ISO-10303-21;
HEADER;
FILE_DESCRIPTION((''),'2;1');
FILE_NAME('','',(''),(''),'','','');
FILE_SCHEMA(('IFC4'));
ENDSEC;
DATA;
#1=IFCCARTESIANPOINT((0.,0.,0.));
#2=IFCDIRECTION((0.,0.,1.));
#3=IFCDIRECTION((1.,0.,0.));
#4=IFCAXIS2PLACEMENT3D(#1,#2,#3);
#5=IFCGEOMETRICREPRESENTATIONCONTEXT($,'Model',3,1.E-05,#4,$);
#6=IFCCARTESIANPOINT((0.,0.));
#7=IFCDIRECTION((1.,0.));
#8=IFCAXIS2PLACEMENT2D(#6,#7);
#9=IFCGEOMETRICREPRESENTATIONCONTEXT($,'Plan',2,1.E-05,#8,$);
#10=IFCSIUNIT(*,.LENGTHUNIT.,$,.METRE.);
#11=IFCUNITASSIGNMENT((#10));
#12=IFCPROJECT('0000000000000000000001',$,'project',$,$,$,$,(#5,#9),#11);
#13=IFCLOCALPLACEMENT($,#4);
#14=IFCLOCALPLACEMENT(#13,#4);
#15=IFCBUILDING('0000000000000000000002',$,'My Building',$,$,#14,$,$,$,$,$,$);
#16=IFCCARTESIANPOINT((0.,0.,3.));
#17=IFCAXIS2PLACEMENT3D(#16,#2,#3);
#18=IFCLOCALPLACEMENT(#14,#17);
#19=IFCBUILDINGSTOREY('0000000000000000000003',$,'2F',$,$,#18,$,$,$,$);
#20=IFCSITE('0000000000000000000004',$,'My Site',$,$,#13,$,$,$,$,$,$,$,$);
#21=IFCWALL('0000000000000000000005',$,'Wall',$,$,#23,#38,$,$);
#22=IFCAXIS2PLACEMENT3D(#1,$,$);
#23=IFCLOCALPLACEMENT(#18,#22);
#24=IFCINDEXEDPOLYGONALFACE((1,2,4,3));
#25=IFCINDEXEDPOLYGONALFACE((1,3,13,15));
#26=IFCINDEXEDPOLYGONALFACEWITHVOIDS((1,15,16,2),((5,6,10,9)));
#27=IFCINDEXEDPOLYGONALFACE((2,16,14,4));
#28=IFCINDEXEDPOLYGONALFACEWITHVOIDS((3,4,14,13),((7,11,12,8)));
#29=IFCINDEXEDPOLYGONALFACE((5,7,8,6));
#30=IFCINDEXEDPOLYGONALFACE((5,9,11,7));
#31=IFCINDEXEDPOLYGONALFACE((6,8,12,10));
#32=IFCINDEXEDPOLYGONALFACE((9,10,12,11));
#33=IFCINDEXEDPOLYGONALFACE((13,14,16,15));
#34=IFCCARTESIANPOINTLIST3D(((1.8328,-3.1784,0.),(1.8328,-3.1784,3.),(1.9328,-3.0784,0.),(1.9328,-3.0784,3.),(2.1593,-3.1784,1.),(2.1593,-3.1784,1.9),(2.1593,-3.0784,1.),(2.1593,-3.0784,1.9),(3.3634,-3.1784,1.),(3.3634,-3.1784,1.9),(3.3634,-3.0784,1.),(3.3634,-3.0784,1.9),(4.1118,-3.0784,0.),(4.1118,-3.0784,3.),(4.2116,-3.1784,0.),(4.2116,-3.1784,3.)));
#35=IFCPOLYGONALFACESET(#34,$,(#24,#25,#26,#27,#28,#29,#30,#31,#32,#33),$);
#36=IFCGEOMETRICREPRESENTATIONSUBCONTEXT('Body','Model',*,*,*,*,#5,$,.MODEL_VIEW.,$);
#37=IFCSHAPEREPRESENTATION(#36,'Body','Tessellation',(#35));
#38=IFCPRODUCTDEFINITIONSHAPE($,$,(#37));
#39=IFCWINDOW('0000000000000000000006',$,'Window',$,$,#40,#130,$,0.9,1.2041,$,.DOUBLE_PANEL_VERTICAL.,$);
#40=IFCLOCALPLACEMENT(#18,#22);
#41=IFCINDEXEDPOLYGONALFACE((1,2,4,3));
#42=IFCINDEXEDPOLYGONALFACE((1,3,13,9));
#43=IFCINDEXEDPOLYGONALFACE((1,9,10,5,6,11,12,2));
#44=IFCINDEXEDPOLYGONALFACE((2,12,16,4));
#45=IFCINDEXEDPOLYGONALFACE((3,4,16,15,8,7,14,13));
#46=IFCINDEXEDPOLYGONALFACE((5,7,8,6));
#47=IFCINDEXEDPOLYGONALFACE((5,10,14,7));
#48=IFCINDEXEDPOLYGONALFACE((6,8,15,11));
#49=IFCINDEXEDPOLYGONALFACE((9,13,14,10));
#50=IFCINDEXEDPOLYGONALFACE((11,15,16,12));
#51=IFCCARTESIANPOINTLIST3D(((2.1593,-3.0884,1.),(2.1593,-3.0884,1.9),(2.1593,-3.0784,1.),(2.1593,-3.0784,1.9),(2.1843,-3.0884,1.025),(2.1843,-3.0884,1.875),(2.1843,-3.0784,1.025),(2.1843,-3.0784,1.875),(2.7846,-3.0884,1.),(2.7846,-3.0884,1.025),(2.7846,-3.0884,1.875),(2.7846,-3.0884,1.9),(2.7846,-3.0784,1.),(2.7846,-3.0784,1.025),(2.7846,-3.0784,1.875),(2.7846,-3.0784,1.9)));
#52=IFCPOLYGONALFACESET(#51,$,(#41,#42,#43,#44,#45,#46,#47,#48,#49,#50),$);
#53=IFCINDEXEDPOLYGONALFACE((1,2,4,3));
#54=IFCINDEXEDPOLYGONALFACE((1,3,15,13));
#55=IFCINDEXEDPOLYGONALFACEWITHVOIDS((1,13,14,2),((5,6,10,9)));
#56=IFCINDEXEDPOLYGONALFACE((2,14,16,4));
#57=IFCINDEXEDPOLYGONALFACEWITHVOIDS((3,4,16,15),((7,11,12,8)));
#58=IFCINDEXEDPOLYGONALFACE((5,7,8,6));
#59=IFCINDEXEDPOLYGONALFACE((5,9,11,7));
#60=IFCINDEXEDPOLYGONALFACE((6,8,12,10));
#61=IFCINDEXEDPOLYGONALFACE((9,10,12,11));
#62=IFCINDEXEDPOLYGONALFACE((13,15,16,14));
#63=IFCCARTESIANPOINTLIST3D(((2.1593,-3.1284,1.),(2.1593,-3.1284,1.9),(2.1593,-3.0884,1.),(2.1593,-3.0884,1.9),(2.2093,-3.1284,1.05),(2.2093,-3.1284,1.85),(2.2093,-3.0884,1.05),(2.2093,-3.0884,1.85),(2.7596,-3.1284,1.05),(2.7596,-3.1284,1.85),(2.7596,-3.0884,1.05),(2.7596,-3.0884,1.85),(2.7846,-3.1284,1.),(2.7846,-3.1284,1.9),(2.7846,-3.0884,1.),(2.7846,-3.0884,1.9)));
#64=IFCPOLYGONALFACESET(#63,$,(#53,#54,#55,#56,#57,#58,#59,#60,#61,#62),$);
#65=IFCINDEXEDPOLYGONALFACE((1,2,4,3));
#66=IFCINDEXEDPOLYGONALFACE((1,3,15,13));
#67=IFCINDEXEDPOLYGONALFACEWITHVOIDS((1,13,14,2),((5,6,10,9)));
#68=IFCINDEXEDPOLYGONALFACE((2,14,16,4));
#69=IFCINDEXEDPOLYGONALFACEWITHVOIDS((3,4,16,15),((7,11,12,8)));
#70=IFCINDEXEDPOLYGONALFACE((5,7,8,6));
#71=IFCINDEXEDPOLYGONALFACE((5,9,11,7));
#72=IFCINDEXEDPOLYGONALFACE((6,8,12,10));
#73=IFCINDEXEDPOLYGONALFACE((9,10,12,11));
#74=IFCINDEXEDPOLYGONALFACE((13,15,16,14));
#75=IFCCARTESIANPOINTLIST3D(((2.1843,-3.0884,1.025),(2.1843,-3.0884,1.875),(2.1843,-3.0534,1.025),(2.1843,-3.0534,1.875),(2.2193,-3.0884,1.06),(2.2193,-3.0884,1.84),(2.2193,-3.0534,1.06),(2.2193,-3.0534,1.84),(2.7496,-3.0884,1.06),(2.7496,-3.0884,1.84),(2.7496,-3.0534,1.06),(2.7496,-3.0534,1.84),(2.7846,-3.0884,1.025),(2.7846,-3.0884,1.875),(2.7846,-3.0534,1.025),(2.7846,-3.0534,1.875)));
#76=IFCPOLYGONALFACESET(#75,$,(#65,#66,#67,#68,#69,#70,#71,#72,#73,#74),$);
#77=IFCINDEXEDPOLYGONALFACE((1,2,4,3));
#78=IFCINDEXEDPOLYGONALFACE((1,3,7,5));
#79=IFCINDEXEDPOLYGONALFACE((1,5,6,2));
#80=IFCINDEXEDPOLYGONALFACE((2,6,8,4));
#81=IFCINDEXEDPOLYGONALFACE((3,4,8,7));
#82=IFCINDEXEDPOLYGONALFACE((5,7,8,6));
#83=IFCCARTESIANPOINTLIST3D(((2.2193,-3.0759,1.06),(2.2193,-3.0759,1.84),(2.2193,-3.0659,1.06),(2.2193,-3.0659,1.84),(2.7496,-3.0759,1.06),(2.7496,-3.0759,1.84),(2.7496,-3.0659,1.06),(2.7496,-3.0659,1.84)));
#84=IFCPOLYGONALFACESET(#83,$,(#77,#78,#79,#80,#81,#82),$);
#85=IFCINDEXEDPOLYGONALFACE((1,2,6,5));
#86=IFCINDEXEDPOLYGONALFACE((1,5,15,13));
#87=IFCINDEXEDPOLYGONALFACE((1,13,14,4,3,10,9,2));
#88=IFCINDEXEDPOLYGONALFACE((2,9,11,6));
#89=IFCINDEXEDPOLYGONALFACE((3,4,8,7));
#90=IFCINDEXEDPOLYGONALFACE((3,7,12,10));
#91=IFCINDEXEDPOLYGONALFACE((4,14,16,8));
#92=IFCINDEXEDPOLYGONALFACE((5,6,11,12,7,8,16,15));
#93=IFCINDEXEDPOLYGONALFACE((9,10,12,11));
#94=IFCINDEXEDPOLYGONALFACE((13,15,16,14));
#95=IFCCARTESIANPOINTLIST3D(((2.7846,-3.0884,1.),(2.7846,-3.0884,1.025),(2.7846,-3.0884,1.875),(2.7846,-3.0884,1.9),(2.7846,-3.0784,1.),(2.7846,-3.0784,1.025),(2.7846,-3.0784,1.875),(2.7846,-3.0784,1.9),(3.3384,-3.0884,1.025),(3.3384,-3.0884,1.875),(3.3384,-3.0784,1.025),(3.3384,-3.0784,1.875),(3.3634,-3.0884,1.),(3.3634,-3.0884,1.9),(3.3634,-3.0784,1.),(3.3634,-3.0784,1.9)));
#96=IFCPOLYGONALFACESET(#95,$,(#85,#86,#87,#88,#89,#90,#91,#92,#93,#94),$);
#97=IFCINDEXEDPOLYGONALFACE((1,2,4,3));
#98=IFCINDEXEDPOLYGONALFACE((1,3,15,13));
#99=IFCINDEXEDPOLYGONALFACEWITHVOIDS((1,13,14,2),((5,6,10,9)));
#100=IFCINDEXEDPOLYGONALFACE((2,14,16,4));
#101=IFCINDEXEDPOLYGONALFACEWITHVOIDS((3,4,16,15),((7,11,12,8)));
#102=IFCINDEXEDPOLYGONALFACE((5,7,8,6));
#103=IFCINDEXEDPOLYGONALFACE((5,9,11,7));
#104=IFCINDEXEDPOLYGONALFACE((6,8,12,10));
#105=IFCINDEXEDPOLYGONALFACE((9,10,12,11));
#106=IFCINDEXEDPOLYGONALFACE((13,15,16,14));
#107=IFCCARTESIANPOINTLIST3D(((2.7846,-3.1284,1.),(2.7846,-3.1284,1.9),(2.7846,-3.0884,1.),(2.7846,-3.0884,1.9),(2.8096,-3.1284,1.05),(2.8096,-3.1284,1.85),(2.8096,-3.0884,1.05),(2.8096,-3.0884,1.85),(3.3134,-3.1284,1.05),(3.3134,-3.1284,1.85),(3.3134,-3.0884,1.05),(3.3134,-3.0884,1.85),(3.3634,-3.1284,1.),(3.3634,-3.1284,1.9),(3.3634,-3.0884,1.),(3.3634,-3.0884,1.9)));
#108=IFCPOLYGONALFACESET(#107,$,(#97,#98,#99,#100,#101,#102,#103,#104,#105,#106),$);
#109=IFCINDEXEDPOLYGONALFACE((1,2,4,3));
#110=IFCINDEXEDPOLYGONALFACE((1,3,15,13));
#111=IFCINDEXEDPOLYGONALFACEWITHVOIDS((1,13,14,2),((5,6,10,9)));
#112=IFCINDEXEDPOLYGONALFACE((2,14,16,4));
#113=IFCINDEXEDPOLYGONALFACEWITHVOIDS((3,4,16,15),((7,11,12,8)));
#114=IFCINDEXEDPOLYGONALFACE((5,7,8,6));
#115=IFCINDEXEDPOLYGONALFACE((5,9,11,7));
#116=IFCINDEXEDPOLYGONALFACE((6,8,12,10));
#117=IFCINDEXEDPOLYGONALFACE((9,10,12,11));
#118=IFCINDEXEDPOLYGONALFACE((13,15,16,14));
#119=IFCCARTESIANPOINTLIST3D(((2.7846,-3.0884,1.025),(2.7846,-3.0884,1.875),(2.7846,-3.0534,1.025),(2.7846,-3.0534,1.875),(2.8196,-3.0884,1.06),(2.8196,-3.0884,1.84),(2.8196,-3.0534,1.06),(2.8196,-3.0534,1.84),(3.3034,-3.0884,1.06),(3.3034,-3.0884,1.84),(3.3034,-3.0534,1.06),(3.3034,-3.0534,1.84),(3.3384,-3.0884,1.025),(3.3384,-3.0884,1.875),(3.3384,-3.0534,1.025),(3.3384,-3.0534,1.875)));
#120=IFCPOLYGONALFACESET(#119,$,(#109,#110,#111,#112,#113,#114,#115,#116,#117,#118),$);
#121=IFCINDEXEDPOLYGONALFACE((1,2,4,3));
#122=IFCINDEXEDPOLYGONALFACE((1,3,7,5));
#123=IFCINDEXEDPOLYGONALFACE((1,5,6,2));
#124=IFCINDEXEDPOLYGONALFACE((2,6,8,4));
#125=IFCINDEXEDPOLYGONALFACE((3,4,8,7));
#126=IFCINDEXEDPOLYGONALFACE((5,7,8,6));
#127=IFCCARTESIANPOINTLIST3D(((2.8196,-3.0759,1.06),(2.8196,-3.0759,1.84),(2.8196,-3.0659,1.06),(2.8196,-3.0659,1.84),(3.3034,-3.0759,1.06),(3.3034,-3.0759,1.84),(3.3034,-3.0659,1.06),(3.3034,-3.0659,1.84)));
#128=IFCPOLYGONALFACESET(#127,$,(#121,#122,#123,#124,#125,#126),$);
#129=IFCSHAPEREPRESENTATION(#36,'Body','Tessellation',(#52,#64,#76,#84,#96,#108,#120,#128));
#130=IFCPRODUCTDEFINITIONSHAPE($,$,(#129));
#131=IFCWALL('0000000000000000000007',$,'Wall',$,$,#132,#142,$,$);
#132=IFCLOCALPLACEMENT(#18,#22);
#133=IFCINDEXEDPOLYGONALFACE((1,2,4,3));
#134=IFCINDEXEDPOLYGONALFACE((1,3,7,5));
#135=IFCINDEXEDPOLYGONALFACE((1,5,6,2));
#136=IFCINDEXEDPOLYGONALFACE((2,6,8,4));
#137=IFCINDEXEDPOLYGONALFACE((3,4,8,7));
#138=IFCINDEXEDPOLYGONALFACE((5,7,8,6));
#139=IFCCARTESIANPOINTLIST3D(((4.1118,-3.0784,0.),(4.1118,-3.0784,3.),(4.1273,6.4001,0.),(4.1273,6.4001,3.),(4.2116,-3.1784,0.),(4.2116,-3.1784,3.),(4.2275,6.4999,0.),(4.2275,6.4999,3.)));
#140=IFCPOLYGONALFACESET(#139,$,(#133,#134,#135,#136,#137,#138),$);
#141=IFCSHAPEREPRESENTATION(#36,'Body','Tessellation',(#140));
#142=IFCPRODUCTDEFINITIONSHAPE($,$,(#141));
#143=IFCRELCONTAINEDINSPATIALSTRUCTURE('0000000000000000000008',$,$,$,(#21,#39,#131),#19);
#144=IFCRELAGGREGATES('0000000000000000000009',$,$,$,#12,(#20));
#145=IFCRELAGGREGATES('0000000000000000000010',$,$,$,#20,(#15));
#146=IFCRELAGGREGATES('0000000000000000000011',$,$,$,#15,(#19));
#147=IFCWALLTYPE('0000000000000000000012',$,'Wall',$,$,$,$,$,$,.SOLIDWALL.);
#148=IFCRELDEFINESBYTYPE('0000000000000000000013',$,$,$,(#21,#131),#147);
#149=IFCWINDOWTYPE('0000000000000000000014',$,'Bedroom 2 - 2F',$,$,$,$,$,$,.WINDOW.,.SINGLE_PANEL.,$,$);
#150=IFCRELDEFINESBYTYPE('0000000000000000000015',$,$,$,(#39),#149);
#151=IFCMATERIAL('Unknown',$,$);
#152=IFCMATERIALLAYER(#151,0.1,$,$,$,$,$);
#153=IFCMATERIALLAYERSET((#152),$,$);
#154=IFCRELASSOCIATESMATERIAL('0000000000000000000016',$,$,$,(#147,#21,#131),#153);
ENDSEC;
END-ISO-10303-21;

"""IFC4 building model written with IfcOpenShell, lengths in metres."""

from ifc_helpers import new_model, entity, si_unit, frame, origin_with_axes, origin_2d_with_axis, place, context, subcontext, project, spatial, line, indexed_curve, outline, extrude, shape, source, transform, mapped, material, layer, layer_set, layer_usage, type_object, type_shapes, element, fill, save


model = new_model("IFC4")

# Units and contexts
model_context = context("Model", 3, precision=1e-05, world=origin_with_axes())
plan_context = context("Plan", 2, precision=1e-05, world=origin_2d_with_axis())
body_context_1 = subcontext(model_context, "Body", "Model", "MODEL_VIEW")
body_context_2 = subcontext(plan_context, "Body", "Plan", "PLAN_VIEW")
ifc_project = project(units=[si_unit("LENGTHUNIT", "METRE")], contexts=[model_context, plan_context])

# Site, building, storey
site_placement = place(None, origin_with_axes())
site = spatial("IfcSite", under=ifc_project, at=site_placement, Name="My Site")
building_placement = place(site_placement, origin_with_axes())
building = spatial("IfcBuilding", under=site, at=building_placement, Name="My Building")
storey_placement = place(building_placement, frame((0.0, 0.0, 3.0), z_axis=(0.0, 0.0, 1.0), x_axis=(1.0, 0.0, 0.0)))
storey = spatial("IfcBuildingStorey", under=building, at=storey_placement, Name="2F")

# Shared definitions
ifc_material = material(Name="Unknown")

# Shared definitions
ifc_layer = layer(ifc_material, 0.1)
ifc_layer_set = layer_set([ifc_layer])
wall_type = type_object("IfcWallType", Name="Wall", PredefinedType="SOLIDWALL", material=ifc_layer_set)

# Wall, opening, window
ifc_layer_usage_1 = layer_usage(ifc_layer_set, "AXIS2", "POSITIVE", 0.0)
wall_1_placement = place(storey_placement, frame((1.8328, -3.1784, 0.0), z_axis=(0.0, 0.0, 1.0), x_axis=(1.0, 0.0, 0.0)))
wall_1 = element("IfcWall", 1, at=wall_1_placement, inside=storey, type_object=wall_type, material=ifc_layer_usage_1, Name="Wall", context=body_context_1, shape_type="SweptSolid", body=[
    extrude(outline(indexed_curve([(0.0, 0.0), (0.1, 0.1), (2.279, 0.1), (2.3789, 0.0)], segments=[line(1, 2, 3, 4, 1)])), origin_with_axes(), (0.0, 0.0, 1.0), 3.0),
])
shared_shape_1 = source(origin_with_axes(), body_context_1, "Body", "SweptSolid", [
    extrude(outline(indexed_curve([(0.0, 0.0), (1.2041, 0.0), (1.2041, 0.9), (0.0, 0.9)], segments=[line(1, 2, 3, 4, 1)])), frame((0.0, -0.6, 0.0), z_axis=(0.0, -1.0, 0.0), x_axis=(1.0, 0.0, 0.0)), (0.0, 0.0, -1.0), 1.2),
])
opening_1_placement = place(wall_1_placement, frame((0.3266, 0.0, 1.0), z_axis=(0.0, 0.0, 1.0), x_axis=(1.0, 0.0, 0.0)))
opening_1 = element("IfcOpeningElement", 2, at=opening_1_placement, cuts=wall_1, PredefinedType="OPENING", context=body_context_1, shape_type="MappedRepresentation", body=[
    mapped(shared_shape_1, transform((0.0, 0.0, 0.0), x_axis=(1.0, 0.0, 0.0), y_axis=(0.0, 1.0, 0.0), z_axis=(0.0, 0.0, 1.0), scale=1.0)),
])
window_type = type_object("IfcWindowType", Name="Bedroom 2 - 2F", PartitioningType="SINGLE_PANEL", PredefinedType="WINDOW")
shared_shape_2 = source(origin_with_axes(), body_context_1, "Body", "SweptSolid", [
    extrude(outline(indexed_curve([(0.6253, 0.0), (0.0, 0.0), (0.0, 0.9), (0.6253, 0.9), (0.6253, 0.875), (0.025, 0.875), (0.025, 0.025), (0.6253, 0.025)], segments=[line(1, 2, 3, 4, 5, 6, 7, 8, 1)])), frame((0.0, 0.09, 0.0), z_axis=(0.0, -1.0, 0.0), x_axis=(1.0, 0.0, 0.0)), (0.0, 0.0, -1.0), 0.01),
    extrude(outline(indexed_curve([(0.0, 0.0), (0.6253, 0.0), (0.6253, 0.9), (0.0, 0.9)], segments=[line(1, 2, 3, 4, 1)]), holes=[indexed_curve([(0.05, 0.05), (0.6003, 0.05), (0.6003, 0.85), (0.05, 0.85)], segments=[line(1, 2, 3, 4, 1)])]), frame((0.0, 0.05, 0.0), z_axis=(0.0, -1.0, 0.0), x_axis=(1.0, 0.0, 0.0)), (0.0, 0.0, -1.0), 0.04),
    extrude(outline(indexed_curve([(0.0, 0.0), (0.6003, 0.0), (0.6003, 0.85), (0.0, 0.85)], segments=[line(1, 2, 3, 4, 1)]), holes=[indexed_curve([(0.035, 0.035), (0.5653, 0.035), (0.5653, 0.815), (0.035, 0.815)], segments=[line(1, 2, 3, 4, 1)])]), frame((0.025, 0.09, 0.025), z_axis=(0.0, -1.0, 0.0), x_axis=(1.0, 0.0, 0.0)), (0.0, 0.0, -1.0), 0.035),
    extrude(outline(indexed_curve([(0.035, 0.035), (0.5653, 0.035), (0.5653, 0.815), (0.035, 0.815)], segments=[line(1, 2, 3, 4, 1)])), frame((0.025, 0.1025, 0.025), z_axis=(0.0, -1.0, 0.0), x_axis=(1.0, 0.0, 0.0)), (0.0, 0.0, -1.0), 0.01),
    extrude(outline(indexed_curve([(0.0, 0.9), (0.5788, 0.9), (0.5788, 0.0), (0.0, 0.0), (0.0, 0.025), (0.5538, 0.025), (0.5538, 0.875), (0.0, 0.875)], segments=[line(1, 2, 3, 4, 5, 6, 7, 8, 1)])), frame((0.6253, 0.09, 0.0), z_axis=(0.0, -1.0, 0.0), x_axis=(1.0, 0.0, 0.0)), (0.0, 0.0, -1.0), 0.01),
    extrude(outline(indexed_curve([(0.0, 0.0), (0.5788, 0.0), (0.5788, 0.9), (0.0, 0.9)], segments=[line(1, 2, 3, 4, 1)]), holes=[indexed_curve([(0.025, 0.05), (0.5288, 0.05), (0.5288, 0.85), (0.025, 0.85)], segments=[line(1, 2, 3, 4, 1)])]), frame((0.6253, 0.05, 0.0), z_axis=(0.0, -1.0, 0.0), x_axis=(1.0, 0.0, 0.0)), (0.0, 0.0, -1.0), 0.04),
    extrude(outline(indexed_curve([(0.0, 0.0), (0.5538, 0.0), (0.5538, 0.85), (0.0, 0.85)], segments=[line(1, 2, 3, 4, 1)]), holes=[indexed_curve([(0.035, 0.035), (0.5188, 0.035), (0.5188, 0.815), (0.035, 0.815)], segments=[line(1, 2, 3, 4, 1)])]), frame((0.6253, 0.09, 0.025), z_axis=(0.0, -1.0, 0.0), x_axis=(1.0, 0.0, 0.0)), (0.0, 0.0, -1.0), 0.035),
    extrude(outline(indexed_curve([(0.035, 0.035), (0.5188, 0.035), (0.5188, 0.815), (0.035, 0.815)], segments=[line(1, 2, 3, 4, 1)])), frame((0.6253, 0.1025, 0.025), z_axis=(0.0, -1.0, 0.0), x_axis=(1.0, 0.0, 0.0)), (0.0, 0.0, -1.0), 0.01),
])
shared_shape_3 = source(origin_with_axes(), body_context_2, "Body", "Curve2D", [
    entity("IfcIndexedPolyCurve", entity("IfcCartesianPointList2D", [[0.05, 0.05], [0.6003, 0.05]])),
    entity("IfcIndexedPolyCurve", entity("IfcCartesianPointList2D", [[0.0, 0.1], [0.025, 0.1], [0.025, 0.09], [0.05, 0.09], [0.05, 0.05], [0.0, 0.05]]), [entity("IfcLineIndex", [1, 2, 3, 4, 5, 6, 1])]),
    entity("IfcIndexedPolyCurve", entity("IfcCartesianPointList2D", [[0.6253, 0.1], [0.6253, 0.1], [0.6253, 0.09], [0.6003, 0.09], [0.6003, 0.05], [0.6253, 0.05]])),
    entity("IfcIndexedPolyCurve", entity("IfcCartesianPointList2D", [[0.025, 0.09], [0.06, 0.09], [0.06, 0.125], [0.025, 0.125]]), [entity("IfcLineIndex", [1, 2, 3, 4, 1])]),
    entity("IfcIndexedPolyCurve", entity("IfcCartesianPointList2D", [[0.6253, 0.09], [0.5903, 0.09], [0.5903, 0.125], [0.6253, 0.125]]), [entity("IfcLineIndex", [1, 2, 3, 4, 1])]),
    entity("IfcIndexedPolyCurve", entity("IfcCartesianPointList2D", [[0.06, 0.09], [0.5903, 0.09]])),
    entity("IfcIndexedPolyCurve", entity("IfcCartesianPointList2D", [[0.06, 0.125], [0.5903, 0.125]])),
    entity("IfcIndexedPolyCurve", entity("IfcCartesianPointList2D", [[0.06, 0.1075], [0.5903, 0.1075]])),
    entity("IfcIndexedPolyCurve", entity("IfcCartesianPointList2D", [[0.6503, 0.05], [1.1541, 0.05]])),
    entity("IfcIndexedPolyCurve", entity("IfcCartesianPointList2D", [[0.6253, 0.1], [0.6253, 0.1], [0.6253, 0.09], [0.6503, 0.09], [0.6503, 0.05], [0.6253, 0.05]])),
    entity("IfcIndexedPolyCurve", entity("IfcCartesianPointList2D", [[1.2041, 0.1], [1.1791, 0.1], [1.1791, 0.09], [1.1541, 0.09], [1.1541, 0.05], [1.2041, 0.05]]), [entity("IfcLineIndex", [1, 2, 3, 4, 5, 6, 1])]),
    entity("IfcIndexedPolyCurve", entity("IfcCartesianPointList2D", [[0.6253, 0.09], [0.6603, 0.09], [0.6603, 0.125], [0.6253, 0.125]]), [entity("IfcLineIndex", [1, 2, 3, 4, 1])]),
    entity("IfcIndexedPolyCurve", entity("IfcCartesianPointList2D", [[1.1791, 0.09], [1.1441, 0.09], [1.1441, 0.125], [1.1791, 0.125]]), [entity("IfcLineIndex", [1, 2, 3, 4, 1])]),
    entity("IfcIndexedPolyCurve", entity("IfcCartesianPointList2D", [[0.6603, 0.09], [1.1441, 0.09]])),
    entity("IfcIndexedPolyCurve", entity("IfcCartesianPointList2D", [[0.6603, 0.125], [1.1441, 0.125]])),
    entity("IfcIndexedPolyCurve", entity("IfcCartesianPointList2D", [[0.6603, 0.1075], [1.1441, 0.1075]])),
])
type_shapes(window_type, [shared_shape_2, shared_shape_3])
window_placement = place(opening_1_placement, origin_with_axes())
window = element("IfcWindow", 3, at=window_placement, inside=storey, type_object=window_type, Name="Window", OverallHeight=0.9, OverallWidth=1.2041, PartitioningType="DOUBLE_PANEL_VERTICAL", shapes=[
    shape(body_context_1, "Body", "MappedRepresentation", [mapped(shared_shape_2, transform((0.0, 0.0, 0.0), x_axis=(1.0, 0.0, 0.0), y_axis=(0.0, 1.0, 0.0), z_axis=(0.0, 0.0, 1.0), scale=1.0))]),
    shape(body_context_2, "Body", "MappedRepresentation", [mapped(shared_shape_3, transform((0.0, 0.0, 0.0), x_axis=(1.0, 0.0, 0.0), y_axis=(0.0, 1.0, 0.0), z_axis=(0.0, 0.0, 1.0), scale=1.0))]),
])
fill(opening_1, window)

# Wall
ifc_layer_usage_2 = layer_usage(ifc_layer_set, "AXIS2", "POSITIVE", 0.0)
wall_2_placement = place(storey_placement, frame((4.2116, -3.1784, 0.0), z_axis=(0.0, 0.0, 1.0), x_axis=(0.001639, 0.999999, 0.0)))
element("IfcWall", 4, at=wall_2_placement, inside=storey, type_object=wall_type, material=ifc_layer_usage_2, Name="Wall", context=body_context_1, shape_type="SweptSolid", body=[
    extrude(outline(indexed_curve([(0.0, 0.0), (0.0998, 0.1), (9.5783, 0.1), (9.6783, 0.0)], segments=[line(1, 2, 3, 4, 1)])), origin_with_axes(), (0.0, 0.0, 1.0), 3.0),
])

save(model, "model.ifc")
